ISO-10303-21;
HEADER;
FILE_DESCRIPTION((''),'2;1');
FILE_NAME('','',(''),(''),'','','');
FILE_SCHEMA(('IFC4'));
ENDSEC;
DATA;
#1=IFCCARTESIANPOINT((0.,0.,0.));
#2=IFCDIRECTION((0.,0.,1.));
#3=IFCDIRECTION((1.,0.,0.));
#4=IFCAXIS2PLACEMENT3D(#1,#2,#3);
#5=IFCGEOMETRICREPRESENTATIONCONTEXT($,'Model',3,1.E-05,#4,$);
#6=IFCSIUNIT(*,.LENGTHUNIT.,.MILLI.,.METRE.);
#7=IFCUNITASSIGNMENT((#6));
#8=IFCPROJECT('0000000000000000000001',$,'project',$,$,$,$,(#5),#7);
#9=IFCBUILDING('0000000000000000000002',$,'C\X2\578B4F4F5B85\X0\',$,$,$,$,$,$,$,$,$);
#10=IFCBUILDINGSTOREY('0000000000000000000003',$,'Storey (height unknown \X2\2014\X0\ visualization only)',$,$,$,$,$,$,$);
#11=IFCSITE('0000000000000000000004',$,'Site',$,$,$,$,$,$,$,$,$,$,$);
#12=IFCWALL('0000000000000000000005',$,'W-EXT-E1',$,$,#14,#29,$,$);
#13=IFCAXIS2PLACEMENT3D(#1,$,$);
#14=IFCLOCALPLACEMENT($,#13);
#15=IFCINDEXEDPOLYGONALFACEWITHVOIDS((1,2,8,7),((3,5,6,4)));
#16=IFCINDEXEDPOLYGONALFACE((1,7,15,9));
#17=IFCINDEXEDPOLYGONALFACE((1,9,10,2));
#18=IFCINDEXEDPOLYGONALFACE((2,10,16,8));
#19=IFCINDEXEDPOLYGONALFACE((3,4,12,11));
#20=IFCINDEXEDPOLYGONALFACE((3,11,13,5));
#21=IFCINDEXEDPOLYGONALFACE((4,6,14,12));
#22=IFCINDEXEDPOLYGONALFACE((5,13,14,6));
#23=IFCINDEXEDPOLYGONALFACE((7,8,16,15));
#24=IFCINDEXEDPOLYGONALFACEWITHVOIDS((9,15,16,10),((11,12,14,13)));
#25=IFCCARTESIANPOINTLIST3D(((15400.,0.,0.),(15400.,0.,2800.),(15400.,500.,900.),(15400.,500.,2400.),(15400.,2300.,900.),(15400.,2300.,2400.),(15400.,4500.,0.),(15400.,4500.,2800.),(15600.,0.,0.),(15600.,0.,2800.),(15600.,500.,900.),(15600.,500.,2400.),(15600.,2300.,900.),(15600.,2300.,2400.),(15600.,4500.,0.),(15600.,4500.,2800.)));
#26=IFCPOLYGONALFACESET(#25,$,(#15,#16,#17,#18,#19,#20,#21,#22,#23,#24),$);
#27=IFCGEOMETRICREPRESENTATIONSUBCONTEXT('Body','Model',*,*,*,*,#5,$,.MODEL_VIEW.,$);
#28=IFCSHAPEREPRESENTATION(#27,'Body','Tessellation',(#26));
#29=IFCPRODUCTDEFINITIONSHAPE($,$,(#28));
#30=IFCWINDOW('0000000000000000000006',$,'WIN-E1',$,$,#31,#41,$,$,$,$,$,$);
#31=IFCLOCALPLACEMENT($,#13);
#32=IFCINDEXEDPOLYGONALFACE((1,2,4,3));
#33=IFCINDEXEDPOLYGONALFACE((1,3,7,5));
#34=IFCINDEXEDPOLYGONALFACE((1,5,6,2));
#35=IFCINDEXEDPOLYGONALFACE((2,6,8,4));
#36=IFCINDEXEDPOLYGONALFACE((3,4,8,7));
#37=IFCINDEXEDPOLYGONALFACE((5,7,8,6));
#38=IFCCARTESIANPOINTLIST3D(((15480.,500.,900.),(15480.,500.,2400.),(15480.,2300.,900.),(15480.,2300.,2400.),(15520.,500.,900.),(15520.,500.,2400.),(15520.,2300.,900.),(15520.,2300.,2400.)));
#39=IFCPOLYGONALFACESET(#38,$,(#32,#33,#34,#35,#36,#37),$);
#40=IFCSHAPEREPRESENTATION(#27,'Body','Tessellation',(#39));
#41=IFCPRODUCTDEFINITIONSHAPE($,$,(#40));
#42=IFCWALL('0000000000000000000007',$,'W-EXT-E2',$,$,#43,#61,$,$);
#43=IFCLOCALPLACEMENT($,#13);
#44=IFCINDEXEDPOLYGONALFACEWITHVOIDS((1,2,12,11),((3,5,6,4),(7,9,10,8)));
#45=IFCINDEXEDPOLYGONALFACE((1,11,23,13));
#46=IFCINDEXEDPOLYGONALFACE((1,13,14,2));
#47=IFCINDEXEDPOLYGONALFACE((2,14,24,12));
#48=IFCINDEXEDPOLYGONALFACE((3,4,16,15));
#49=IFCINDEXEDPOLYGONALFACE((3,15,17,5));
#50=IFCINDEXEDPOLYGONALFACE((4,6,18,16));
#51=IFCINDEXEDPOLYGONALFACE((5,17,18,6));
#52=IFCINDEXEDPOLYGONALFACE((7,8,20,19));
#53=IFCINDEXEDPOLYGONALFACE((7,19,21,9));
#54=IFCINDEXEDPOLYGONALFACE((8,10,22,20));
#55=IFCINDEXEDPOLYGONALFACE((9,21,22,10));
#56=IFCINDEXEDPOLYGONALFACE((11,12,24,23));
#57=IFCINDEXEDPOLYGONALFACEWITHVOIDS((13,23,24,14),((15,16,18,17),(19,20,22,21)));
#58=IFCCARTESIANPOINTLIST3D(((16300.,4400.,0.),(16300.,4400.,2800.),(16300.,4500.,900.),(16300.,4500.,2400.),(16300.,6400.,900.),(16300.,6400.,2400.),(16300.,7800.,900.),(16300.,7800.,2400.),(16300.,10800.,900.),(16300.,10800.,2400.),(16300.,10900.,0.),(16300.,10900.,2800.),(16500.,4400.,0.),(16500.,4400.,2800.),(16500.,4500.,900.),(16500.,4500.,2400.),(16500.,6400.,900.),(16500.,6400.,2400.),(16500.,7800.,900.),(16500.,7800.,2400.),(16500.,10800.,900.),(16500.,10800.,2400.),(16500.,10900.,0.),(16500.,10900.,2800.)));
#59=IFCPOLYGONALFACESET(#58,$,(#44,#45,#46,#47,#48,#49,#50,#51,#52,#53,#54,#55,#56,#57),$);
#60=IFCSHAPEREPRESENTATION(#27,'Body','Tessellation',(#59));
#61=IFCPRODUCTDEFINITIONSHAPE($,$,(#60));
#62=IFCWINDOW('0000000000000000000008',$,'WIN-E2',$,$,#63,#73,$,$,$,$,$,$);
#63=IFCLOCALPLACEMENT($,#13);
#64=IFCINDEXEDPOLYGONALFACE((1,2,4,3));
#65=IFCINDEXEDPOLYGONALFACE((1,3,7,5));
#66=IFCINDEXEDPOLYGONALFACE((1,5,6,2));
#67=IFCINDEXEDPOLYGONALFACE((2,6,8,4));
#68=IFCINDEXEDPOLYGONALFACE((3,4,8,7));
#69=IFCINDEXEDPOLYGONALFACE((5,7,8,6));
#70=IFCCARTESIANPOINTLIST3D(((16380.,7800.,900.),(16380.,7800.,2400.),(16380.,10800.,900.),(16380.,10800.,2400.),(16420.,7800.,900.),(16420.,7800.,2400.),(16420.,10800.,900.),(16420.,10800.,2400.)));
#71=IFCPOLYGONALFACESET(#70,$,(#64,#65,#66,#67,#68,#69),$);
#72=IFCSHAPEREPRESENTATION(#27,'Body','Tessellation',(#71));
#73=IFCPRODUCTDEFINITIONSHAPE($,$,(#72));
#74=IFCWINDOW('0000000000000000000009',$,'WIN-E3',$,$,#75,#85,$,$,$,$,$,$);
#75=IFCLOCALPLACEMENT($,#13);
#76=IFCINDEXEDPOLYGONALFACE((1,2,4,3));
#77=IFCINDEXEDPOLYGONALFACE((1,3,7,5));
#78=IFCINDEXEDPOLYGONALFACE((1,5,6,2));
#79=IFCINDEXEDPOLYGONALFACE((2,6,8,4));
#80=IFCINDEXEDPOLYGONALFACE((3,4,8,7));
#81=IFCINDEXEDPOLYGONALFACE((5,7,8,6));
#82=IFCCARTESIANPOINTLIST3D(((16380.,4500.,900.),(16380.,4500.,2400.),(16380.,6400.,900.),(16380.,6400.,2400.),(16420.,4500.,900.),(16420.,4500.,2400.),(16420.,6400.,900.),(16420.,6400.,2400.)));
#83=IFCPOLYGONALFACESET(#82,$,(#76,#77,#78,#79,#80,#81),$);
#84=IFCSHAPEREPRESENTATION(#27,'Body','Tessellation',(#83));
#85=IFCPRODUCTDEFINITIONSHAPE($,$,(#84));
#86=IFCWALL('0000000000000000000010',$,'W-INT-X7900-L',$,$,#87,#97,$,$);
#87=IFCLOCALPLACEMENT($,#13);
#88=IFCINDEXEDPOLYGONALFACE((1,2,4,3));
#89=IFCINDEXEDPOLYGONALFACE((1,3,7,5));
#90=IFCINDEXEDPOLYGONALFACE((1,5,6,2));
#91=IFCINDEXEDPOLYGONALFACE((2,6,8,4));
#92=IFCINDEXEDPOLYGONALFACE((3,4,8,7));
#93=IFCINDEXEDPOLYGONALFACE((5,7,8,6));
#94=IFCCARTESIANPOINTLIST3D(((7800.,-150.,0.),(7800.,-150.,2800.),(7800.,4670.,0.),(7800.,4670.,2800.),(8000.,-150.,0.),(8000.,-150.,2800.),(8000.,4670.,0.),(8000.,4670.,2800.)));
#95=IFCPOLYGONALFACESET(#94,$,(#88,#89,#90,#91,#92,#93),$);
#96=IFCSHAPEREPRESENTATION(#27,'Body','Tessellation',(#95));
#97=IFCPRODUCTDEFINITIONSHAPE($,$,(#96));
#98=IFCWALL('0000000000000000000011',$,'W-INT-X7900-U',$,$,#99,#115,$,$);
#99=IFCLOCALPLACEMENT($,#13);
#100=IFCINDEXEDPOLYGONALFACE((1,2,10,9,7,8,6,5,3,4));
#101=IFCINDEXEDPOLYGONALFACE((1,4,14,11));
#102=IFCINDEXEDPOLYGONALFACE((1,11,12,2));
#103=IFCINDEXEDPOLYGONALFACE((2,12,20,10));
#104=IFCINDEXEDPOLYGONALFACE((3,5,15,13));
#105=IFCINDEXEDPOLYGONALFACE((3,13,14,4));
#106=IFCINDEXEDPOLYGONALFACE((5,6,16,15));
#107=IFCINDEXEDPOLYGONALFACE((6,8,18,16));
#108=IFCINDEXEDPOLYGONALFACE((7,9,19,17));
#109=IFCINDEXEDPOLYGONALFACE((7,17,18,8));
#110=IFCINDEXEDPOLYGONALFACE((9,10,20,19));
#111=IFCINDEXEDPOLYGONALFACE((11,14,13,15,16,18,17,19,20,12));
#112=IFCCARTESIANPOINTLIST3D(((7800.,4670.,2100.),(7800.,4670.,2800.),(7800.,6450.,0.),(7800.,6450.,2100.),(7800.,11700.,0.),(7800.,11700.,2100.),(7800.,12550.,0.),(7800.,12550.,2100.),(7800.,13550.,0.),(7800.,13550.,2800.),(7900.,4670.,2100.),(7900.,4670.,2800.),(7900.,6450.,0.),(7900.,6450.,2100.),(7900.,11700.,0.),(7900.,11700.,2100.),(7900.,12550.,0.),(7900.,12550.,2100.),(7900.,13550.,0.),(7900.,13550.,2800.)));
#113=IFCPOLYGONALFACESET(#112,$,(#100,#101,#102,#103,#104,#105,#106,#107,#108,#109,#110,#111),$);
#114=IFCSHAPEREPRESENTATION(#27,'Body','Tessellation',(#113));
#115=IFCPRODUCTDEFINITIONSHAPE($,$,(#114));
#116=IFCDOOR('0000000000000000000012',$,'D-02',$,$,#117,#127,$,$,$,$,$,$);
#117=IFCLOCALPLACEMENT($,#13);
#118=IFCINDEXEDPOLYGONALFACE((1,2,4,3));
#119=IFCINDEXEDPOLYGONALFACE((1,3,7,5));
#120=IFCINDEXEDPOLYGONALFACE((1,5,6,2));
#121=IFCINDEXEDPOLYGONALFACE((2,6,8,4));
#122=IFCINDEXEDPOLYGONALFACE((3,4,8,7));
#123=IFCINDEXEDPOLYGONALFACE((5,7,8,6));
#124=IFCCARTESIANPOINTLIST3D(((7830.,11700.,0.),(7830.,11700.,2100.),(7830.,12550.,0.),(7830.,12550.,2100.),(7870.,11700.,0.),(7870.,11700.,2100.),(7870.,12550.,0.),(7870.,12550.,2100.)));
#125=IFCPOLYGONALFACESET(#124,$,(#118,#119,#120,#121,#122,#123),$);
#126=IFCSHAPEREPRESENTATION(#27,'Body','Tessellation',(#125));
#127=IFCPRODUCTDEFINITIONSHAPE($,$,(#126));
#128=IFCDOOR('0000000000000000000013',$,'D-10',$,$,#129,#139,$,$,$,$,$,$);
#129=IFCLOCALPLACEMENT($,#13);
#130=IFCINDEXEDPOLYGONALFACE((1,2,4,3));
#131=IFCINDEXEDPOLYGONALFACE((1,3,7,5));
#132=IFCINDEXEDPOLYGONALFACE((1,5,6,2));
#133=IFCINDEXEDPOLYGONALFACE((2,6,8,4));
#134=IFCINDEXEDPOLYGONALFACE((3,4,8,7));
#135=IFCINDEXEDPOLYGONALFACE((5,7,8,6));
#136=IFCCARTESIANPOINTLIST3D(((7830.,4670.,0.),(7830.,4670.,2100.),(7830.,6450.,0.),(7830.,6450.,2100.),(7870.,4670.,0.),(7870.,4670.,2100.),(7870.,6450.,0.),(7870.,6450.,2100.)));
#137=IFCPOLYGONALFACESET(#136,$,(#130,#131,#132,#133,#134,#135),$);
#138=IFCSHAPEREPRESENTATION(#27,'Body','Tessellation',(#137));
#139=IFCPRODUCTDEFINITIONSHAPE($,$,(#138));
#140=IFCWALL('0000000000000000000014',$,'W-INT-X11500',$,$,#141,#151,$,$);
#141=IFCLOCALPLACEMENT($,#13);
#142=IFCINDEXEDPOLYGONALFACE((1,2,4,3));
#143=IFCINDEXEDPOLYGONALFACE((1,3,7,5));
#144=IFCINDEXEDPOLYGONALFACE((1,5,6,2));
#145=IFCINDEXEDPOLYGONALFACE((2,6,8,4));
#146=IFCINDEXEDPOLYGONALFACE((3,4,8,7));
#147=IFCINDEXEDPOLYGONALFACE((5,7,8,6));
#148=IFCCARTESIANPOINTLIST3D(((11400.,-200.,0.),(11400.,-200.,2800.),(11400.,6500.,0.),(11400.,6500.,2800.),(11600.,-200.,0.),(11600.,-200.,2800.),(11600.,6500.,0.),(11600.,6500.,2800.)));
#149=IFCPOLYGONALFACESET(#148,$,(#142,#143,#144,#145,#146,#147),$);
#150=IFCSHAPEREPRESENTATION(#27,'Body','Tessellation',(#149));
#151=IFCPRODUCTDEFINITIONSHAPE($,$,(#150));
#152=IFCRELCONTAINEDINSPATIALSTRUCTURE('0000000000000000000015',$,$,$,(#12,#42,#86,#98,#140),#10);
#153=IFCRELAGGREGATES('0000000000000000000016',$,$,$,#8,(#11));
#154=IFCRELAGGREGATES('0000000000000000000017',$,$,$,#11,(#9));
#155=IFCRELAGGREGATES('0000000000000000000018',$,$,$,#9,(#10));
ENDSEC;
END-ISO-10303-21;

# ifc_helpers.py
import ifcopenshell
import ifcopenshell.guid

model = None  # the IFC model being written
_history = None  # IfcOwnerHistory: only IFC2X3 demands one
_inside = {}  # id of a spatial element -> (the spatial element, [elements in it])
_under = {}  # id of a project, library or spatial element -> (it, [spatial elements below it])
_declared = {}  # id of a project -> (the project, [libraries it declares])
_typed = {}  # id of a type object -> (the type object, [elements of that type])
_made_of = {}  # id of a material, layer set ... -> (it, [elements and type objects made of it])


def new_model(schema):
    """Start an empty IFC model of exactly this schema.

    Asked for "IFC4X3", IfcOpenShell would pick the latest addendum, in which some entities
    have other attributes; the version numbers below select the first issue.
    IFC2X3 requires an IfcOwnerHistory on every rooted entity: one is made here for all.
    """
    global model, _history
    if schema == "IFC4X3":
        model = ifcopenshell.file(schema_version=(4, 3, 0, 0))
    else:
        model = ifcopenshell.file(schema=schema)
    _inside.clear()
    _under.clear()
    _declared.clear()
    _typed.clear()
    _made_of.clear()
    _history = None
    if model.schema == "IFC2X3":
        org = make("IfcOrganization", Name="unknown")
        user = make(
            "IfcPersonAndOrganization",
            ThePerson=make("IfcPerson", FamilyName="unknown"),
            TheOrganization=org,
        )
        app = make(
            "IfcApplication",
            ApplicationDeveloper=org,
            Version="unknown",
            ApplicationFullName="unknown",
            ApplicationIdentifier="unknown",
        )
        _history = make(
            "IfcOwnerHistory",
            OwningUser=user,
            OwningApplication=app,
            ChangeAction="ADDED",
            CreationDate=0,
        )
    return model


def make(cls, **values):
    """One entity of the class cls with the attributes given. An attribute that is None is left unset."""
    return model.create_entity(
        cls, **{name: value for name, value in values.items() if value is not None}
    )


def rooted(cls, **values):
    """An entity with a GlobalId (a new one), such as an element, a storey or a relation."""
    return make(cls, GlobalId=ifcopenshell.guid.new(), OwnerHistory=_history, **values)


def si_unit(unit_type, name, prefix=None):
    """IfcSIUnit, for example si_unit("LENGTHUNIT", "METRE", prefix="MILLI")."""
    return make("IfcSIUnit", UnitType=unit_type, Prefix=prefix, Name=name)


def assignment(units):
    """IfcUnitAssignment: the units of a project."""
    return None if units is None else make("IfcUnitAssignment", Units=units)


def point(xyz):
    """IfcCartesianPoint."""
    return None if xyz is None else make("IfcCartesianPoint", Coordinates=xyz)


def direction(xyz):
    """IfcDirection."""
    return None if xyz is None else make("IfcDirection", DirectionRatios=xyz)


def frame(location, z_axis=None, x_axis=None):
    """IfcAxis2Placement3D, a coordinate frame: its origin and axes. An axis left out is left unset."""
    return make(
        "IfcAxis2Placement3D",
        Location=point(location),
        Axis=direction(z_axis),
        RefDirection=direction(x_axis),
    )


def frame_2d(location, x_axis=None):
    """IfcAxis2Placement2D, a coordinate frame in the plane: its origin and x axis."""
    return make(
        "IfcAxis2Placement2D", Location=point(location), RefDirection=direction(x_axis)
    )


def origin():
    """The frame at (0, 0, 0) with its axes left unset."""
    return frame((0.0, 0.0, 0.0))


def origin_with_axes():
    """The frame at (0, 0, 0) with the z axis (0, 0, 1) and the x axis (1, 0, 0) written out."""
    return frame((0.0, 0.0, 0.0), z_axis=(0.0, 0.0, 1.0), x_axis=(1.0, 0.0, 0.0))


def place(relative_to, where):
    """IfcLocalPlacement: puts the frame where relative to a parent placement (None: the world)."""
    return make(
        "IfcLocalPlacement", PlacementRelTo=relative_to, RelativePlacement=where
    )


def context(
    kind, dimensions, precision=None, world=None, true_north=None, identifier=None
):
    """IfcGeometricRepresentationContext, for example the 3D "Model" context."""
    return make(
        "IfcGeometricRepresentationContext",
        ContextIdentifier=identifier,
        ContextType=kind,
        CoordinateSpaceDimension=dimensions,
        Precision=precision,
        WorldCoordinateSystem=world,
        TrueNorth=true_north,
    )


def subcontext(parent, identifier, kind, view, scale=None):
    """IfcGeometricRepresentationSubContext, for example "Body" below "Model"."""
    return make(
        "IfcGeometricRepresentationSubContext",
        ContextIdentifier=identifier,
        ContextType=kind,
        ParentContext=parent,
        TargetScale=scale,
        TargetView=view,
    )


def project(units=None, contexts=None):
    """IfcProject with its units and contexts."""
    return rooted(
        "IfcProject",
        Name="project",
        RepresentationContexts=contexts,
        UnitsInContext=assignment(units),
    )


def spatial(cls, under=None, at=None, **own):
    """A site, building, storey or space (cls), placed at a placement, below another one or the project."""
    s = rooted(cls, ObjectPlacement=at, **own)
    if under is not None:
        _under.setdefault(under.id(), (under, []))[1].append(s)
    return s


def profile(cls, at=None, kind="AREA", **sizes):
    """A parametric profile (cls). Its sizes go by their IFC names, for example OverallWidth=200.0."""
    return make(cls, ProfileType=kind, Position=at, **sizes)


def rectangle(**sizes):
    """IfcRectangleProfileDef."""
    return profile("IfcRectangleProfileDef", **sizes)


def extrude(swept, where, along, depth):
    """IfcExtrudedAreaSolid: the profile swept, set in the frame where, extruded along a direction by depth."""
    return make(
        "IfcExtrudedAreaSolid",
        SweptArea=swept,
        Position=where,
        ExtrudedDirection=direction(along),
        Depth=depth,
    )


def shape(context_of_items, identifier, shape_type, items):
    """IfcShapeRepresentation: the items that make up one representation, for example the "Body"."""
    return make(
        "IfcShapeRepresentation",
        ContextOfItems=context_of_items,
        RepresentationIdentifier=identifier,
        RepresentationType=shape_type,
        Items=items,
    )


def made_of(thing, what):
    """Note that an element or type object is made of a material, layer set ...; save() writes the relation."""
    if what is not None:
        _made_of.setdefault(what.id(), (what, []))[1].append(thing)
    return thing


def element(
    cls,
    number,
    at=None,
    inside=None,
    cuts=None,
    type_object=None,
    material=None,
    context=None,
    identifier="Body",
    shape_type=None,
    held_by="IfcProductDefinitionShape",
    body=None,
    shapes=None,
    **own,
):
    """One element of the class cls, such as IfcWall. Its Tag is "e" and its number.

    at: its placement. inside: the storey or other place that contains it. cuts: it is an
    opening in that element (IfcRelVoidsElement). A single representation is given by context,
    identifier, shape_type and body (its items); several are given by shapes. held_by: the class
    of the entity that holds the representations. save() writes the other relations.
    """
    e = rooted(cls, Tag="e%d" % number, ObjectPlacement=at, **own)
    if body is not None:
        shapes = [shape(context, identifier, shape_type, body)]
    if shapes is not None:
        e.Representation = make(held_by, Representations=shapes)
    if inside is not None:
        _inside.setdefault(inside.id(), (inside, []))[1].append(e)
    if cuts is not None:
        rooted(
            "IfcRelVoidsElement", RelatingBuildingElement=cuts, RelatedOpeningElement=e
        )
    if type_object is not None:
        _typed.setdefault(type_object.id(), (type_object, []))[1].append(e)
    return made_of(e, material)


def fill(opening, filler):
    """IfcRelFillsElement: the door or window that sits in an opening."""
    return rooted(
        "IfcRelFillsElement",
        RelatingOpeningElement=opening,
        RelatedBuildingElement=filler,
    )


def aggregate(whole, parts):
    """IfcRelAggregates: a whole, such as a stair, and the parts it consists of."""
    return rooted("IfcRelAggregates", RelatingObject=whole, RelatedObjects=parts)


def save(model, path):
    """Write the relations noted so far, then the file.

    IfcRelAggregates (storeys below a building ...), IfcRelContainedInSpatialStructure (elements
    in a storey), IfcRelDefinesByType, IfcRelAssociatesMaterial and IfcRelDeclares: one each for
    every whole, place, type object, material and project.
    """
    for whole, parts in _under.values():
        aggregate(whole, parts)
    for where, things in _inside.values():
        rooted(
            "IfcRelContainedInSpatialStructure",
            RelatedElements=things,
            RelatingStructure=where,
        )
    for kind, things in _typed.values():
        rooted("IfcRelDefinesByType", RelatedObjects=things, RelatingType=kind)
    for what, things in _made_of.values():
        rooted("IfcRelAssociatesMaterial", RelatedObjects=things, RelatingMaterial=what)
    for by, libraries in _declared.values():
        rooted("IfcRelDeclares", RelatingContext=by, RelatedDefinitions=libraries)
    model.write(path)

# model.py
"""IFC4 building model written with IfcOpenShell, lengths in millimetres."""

from ifc_helpers import new_model, si_unit, frame, frame_2d, origin, origin_with_axes, place, context, subcontext, project, spatial, rectangle, extrude, element, fill, save


model = new_model("IFC4")

# Units and contexts
model_context = context("Model", 3, precision=1e-05, world=origin_with_axes())
body_context = subcontext(model_context, "Body", "Model", "MODEL_VIEW")
ifc_project = project(units=[si_unit("LENGTHUNIT", "METRE", prefix="MILLI")], contexts=[model_context])

# Site, building, storey
site = spatial("IfcSite", under=ifc_project, Name="Site")
building = spatial("IfcBuilding", under=site, Name="C型住宅")
storey = spatial("IfcBuildingStorey", under=building, Name="Storey (height unknown — visualization only)")

# Wall, opening, window
wall_1_placement = place(None, frame((15400.0, 0.0, 0.0), z_axis=(0.0, 0.0, 1.0), x_axis=(1.0, 0.0, 0.0)))
wall_1 = element("IfcWall", 1, at=wall_1_placement, inside=storey, Name="W-EXT-E1", context=body_context, shape_type="SweptSolid", body=[
    extrude(rectangle(XDim=200.0, YDim=4500.0, at=frame_2d((100.0, 2250.0))), origin_with_axes(), (0.0, 0.0, 1.0), 2800.0),
])
opening_1_placement = place(wall_1_placement, frame((0.0, 500.0, 900.0)))
opening_1 = element("IfcOpeningElement", 2, at=opening_1_placement, cuts=wall_1, context=body_context, shape_type="SweptSolid", body=[
    extrude(rectangle(XDim=200.0, YDim=1800.0, at=frame_2d((100.0, 900.0))), origin_with_axes(), (0.0, 0.0, 1.0), 1500.0),
])
window_1_placement = place(wall_1_placement, frame((80.0, 500.0, 900.0)))
window_1 = element("IfcWindow", 3, at=window_1_placement, Name="WIN-E1", context=body_context, shape_type="SweptSolid", body=[
    extrude(rectangle(XDim=40.0, YDim=1800.0, at=frame_2d((20.0, 900.0))), origin_with_axes(), (0.0, 0.0, 1.0), 1500.0),
])
fill(opening_1, window_1)

# Wall, openings, windows
wall_2_placement = place(None, frame((16300.0, 4400.0, 0.0), z_axis=(0.0, 0.0, 1.0), x_axis=(1.0, 0.0, 0.0)))
wall_2 = element("IfcWall", 4, at=wall_2_placement, inside=storey, Name="W-EXT-E2", context=body_context, shape_type="SweptSolid", body=[
    extrude(rectangle(XDim=200.0, YDim=6500.0, at=frame_2d((100.0, 3250.0))), origin_with_axes(), (0.0, 0.0, 1.0), 2800.0),
])
opening_2_placement = place(wall_2_placement, frame((0.0, 3400.0, 900.0)))
opening_2 = element("IfcOpeningElement", 5, at=opening_2_placement, cuts=wall_2, context=body_context, shape_type="SweptSolid", body=[
    extrude(rectangle(XDim=200.0, YDim=3000.0, at=frame_2d((100.0, 1500.0))), origin_with_axes(), (0.0, 0.0, 1.0), 1500.0),
])
opening_3_placement = place(wall_2_placement, frame((0.0, 100.0, 900.0)))
opening_3 = element("IfcOpeningElement", 6, at=opening_3_placement, cuts=wall_2, context=body_context, shape_type="SweptSolid", body=[
    extrude(rectangle(XDim=200.0, YDim=1900.0, at=frame_2d((100.0, 950.0))), origin_with_axes(), (0.0, 0.0, 1.0), 1500.0),
])
window_2_placement = place(wall_2_placement, frame((80.0, 3400.0, 900.0)))
window_2 = element("IfcWindow", 7, at=window_2_placement, Name="WIN-E2", context=body_context, shape_type="SweptSolid", body=[
    extrude(rectangle(XDim=40.0, YDim=3000.0, at=frame_2d((20.0, 1500.0))), origin_with_axes(), (0.0, 0.0, 1.0), 1500.0),
])
fill(opening_2, window_2)
window_3_placement = place(wall_2_placement, frame((80.0, 100.0, 900.0)))
window_3 = element("IfcWindow", 8, at=window_3_placement, Name="WIN-E3", context=body_context, shape_type="SweptSolid", body=[
    extrude(rectangle(XDim=40.0, YDim=1900.0, at=frame_2d((20.0, 950.0))), origin_with_axes(), (0.0, 0.0, 1.0), 1500.0),
])
fill(opening_3, window_3)

# Wall
wall_3_placement = place(None, frame((7800.0, -150.0, 0.0), z_axis=(0.0, 0.0, 1.0), x_axis=(1.0, 0.0, 0.0)))
element("IfcWall", 9, at=wall_3_placement, inside=storey, Name="W-INT-X7900-L", context=body_context, shape_type="SweptSolid", body=[
    extrude(rectangle(XDim=200.0, YDim=4820.0, at=frame_2d((100.0, 2410.0))), origin_with_axes(), (0.0, 0.0, 1.0), 2800.0),
])

# Wall, openings, doors
wall_4_placement = place(None, frame((7800.0, 4670.0, 0.0), z_axis=(0.0, 0.0, 1.0), x_axis=(1.0, 0.0, 0.0)))
wall_4 = element("IfcWall", 10, at=wall_4_placement, inside=storey, Name="W-INT-X7900-U", context=body_context, shape_type="SweptSolid", body=[
    extrude(rectangle(XDim=100.0, YDim=8880.0, at=frame_2d((50.0, 4440.0))), origin_with_axes(), (0.0, 0.0, 1.0), 2800.0),
])
opening_4_placement = place(wall_4_placement, frame((0.0, 7030.0, 0.0)))
opening_4 = element("IfcOpeningElement", 11, at=opening_4_placement, cuts=wall_4, context=body_context, shape_type="SweptSolid", body=[
    extrude(rectangle(XDim=100.0, YDim=850.0, at=frame_2d((50.0, 425.0))), origin_with_axes(), (0.0, 0.0, 1.0), 2100.0),
])
opening_5_placement = place(wall_4_placement, origin())
opening_5 = element("IfcOpeningElement", 12, at=opening_5_placement, cuts=wall_4, context=body_context, shape_type="SweptSolid", body=[
    extrude(rectangle(XDim=100.0, YDim=1780.0, at=frame_2d((50.0, 890.0))), origin_with_axes(), (0.0, 0.0, 1.0), 2100.0),
])
door_1_placement = place(wall_4_placement, frame((30.0, 7030.0, 0.0)))
door_1 = element("IfcDoor", 13, at=door_1_placement, Name="D-02", context=body_context, shape_type="SweptSolid", body=[
    extrude(rectangle(XDim=40.0, YDim=850.0, at=frame_2d((20.0, 425.0))), origin_with_axes(), (0.0, 0.0, 1.0), 2100.0),
])
fill(opening_4, door_1)
door_2_placement = place(wall_4_placement, frame((30.0, 0.0, 0.0)))
door_2 = element("IfcDoor", 14, at=door_2_placement, Name="D-10", context=body_context, shape_type="SweptSolid", body=[
    extrude(rectangle(XDim=40.0, YDim=1780.0, at=frame_2d((20.0, 890.0))), origin_with_axes(), (0.0, 0.0, 1.0), 2100.0),
])
fill(opening_5, door_2)

# Wall
wall_5_placement = place(None, frame((11400.0, -200.0, 0.0), z_axis=(0.0, 0.0, 1.0), x_axis=(1.0, 0.0, 0.0)))
element("IfcWall", 15, at=wall_5_placement, inside=storey, Name="W-INT-X11500", context=body_context, shape_type="SweptSolid", body=[
    extrude(rectangle(XDim=200.0, YDim=6700.0, at=frame_2d((100.0, 3350.0))), origin_with_axes(), (0.0, 0.0, 1.0), 2800.0),
])

save(model, "model.ifc")
